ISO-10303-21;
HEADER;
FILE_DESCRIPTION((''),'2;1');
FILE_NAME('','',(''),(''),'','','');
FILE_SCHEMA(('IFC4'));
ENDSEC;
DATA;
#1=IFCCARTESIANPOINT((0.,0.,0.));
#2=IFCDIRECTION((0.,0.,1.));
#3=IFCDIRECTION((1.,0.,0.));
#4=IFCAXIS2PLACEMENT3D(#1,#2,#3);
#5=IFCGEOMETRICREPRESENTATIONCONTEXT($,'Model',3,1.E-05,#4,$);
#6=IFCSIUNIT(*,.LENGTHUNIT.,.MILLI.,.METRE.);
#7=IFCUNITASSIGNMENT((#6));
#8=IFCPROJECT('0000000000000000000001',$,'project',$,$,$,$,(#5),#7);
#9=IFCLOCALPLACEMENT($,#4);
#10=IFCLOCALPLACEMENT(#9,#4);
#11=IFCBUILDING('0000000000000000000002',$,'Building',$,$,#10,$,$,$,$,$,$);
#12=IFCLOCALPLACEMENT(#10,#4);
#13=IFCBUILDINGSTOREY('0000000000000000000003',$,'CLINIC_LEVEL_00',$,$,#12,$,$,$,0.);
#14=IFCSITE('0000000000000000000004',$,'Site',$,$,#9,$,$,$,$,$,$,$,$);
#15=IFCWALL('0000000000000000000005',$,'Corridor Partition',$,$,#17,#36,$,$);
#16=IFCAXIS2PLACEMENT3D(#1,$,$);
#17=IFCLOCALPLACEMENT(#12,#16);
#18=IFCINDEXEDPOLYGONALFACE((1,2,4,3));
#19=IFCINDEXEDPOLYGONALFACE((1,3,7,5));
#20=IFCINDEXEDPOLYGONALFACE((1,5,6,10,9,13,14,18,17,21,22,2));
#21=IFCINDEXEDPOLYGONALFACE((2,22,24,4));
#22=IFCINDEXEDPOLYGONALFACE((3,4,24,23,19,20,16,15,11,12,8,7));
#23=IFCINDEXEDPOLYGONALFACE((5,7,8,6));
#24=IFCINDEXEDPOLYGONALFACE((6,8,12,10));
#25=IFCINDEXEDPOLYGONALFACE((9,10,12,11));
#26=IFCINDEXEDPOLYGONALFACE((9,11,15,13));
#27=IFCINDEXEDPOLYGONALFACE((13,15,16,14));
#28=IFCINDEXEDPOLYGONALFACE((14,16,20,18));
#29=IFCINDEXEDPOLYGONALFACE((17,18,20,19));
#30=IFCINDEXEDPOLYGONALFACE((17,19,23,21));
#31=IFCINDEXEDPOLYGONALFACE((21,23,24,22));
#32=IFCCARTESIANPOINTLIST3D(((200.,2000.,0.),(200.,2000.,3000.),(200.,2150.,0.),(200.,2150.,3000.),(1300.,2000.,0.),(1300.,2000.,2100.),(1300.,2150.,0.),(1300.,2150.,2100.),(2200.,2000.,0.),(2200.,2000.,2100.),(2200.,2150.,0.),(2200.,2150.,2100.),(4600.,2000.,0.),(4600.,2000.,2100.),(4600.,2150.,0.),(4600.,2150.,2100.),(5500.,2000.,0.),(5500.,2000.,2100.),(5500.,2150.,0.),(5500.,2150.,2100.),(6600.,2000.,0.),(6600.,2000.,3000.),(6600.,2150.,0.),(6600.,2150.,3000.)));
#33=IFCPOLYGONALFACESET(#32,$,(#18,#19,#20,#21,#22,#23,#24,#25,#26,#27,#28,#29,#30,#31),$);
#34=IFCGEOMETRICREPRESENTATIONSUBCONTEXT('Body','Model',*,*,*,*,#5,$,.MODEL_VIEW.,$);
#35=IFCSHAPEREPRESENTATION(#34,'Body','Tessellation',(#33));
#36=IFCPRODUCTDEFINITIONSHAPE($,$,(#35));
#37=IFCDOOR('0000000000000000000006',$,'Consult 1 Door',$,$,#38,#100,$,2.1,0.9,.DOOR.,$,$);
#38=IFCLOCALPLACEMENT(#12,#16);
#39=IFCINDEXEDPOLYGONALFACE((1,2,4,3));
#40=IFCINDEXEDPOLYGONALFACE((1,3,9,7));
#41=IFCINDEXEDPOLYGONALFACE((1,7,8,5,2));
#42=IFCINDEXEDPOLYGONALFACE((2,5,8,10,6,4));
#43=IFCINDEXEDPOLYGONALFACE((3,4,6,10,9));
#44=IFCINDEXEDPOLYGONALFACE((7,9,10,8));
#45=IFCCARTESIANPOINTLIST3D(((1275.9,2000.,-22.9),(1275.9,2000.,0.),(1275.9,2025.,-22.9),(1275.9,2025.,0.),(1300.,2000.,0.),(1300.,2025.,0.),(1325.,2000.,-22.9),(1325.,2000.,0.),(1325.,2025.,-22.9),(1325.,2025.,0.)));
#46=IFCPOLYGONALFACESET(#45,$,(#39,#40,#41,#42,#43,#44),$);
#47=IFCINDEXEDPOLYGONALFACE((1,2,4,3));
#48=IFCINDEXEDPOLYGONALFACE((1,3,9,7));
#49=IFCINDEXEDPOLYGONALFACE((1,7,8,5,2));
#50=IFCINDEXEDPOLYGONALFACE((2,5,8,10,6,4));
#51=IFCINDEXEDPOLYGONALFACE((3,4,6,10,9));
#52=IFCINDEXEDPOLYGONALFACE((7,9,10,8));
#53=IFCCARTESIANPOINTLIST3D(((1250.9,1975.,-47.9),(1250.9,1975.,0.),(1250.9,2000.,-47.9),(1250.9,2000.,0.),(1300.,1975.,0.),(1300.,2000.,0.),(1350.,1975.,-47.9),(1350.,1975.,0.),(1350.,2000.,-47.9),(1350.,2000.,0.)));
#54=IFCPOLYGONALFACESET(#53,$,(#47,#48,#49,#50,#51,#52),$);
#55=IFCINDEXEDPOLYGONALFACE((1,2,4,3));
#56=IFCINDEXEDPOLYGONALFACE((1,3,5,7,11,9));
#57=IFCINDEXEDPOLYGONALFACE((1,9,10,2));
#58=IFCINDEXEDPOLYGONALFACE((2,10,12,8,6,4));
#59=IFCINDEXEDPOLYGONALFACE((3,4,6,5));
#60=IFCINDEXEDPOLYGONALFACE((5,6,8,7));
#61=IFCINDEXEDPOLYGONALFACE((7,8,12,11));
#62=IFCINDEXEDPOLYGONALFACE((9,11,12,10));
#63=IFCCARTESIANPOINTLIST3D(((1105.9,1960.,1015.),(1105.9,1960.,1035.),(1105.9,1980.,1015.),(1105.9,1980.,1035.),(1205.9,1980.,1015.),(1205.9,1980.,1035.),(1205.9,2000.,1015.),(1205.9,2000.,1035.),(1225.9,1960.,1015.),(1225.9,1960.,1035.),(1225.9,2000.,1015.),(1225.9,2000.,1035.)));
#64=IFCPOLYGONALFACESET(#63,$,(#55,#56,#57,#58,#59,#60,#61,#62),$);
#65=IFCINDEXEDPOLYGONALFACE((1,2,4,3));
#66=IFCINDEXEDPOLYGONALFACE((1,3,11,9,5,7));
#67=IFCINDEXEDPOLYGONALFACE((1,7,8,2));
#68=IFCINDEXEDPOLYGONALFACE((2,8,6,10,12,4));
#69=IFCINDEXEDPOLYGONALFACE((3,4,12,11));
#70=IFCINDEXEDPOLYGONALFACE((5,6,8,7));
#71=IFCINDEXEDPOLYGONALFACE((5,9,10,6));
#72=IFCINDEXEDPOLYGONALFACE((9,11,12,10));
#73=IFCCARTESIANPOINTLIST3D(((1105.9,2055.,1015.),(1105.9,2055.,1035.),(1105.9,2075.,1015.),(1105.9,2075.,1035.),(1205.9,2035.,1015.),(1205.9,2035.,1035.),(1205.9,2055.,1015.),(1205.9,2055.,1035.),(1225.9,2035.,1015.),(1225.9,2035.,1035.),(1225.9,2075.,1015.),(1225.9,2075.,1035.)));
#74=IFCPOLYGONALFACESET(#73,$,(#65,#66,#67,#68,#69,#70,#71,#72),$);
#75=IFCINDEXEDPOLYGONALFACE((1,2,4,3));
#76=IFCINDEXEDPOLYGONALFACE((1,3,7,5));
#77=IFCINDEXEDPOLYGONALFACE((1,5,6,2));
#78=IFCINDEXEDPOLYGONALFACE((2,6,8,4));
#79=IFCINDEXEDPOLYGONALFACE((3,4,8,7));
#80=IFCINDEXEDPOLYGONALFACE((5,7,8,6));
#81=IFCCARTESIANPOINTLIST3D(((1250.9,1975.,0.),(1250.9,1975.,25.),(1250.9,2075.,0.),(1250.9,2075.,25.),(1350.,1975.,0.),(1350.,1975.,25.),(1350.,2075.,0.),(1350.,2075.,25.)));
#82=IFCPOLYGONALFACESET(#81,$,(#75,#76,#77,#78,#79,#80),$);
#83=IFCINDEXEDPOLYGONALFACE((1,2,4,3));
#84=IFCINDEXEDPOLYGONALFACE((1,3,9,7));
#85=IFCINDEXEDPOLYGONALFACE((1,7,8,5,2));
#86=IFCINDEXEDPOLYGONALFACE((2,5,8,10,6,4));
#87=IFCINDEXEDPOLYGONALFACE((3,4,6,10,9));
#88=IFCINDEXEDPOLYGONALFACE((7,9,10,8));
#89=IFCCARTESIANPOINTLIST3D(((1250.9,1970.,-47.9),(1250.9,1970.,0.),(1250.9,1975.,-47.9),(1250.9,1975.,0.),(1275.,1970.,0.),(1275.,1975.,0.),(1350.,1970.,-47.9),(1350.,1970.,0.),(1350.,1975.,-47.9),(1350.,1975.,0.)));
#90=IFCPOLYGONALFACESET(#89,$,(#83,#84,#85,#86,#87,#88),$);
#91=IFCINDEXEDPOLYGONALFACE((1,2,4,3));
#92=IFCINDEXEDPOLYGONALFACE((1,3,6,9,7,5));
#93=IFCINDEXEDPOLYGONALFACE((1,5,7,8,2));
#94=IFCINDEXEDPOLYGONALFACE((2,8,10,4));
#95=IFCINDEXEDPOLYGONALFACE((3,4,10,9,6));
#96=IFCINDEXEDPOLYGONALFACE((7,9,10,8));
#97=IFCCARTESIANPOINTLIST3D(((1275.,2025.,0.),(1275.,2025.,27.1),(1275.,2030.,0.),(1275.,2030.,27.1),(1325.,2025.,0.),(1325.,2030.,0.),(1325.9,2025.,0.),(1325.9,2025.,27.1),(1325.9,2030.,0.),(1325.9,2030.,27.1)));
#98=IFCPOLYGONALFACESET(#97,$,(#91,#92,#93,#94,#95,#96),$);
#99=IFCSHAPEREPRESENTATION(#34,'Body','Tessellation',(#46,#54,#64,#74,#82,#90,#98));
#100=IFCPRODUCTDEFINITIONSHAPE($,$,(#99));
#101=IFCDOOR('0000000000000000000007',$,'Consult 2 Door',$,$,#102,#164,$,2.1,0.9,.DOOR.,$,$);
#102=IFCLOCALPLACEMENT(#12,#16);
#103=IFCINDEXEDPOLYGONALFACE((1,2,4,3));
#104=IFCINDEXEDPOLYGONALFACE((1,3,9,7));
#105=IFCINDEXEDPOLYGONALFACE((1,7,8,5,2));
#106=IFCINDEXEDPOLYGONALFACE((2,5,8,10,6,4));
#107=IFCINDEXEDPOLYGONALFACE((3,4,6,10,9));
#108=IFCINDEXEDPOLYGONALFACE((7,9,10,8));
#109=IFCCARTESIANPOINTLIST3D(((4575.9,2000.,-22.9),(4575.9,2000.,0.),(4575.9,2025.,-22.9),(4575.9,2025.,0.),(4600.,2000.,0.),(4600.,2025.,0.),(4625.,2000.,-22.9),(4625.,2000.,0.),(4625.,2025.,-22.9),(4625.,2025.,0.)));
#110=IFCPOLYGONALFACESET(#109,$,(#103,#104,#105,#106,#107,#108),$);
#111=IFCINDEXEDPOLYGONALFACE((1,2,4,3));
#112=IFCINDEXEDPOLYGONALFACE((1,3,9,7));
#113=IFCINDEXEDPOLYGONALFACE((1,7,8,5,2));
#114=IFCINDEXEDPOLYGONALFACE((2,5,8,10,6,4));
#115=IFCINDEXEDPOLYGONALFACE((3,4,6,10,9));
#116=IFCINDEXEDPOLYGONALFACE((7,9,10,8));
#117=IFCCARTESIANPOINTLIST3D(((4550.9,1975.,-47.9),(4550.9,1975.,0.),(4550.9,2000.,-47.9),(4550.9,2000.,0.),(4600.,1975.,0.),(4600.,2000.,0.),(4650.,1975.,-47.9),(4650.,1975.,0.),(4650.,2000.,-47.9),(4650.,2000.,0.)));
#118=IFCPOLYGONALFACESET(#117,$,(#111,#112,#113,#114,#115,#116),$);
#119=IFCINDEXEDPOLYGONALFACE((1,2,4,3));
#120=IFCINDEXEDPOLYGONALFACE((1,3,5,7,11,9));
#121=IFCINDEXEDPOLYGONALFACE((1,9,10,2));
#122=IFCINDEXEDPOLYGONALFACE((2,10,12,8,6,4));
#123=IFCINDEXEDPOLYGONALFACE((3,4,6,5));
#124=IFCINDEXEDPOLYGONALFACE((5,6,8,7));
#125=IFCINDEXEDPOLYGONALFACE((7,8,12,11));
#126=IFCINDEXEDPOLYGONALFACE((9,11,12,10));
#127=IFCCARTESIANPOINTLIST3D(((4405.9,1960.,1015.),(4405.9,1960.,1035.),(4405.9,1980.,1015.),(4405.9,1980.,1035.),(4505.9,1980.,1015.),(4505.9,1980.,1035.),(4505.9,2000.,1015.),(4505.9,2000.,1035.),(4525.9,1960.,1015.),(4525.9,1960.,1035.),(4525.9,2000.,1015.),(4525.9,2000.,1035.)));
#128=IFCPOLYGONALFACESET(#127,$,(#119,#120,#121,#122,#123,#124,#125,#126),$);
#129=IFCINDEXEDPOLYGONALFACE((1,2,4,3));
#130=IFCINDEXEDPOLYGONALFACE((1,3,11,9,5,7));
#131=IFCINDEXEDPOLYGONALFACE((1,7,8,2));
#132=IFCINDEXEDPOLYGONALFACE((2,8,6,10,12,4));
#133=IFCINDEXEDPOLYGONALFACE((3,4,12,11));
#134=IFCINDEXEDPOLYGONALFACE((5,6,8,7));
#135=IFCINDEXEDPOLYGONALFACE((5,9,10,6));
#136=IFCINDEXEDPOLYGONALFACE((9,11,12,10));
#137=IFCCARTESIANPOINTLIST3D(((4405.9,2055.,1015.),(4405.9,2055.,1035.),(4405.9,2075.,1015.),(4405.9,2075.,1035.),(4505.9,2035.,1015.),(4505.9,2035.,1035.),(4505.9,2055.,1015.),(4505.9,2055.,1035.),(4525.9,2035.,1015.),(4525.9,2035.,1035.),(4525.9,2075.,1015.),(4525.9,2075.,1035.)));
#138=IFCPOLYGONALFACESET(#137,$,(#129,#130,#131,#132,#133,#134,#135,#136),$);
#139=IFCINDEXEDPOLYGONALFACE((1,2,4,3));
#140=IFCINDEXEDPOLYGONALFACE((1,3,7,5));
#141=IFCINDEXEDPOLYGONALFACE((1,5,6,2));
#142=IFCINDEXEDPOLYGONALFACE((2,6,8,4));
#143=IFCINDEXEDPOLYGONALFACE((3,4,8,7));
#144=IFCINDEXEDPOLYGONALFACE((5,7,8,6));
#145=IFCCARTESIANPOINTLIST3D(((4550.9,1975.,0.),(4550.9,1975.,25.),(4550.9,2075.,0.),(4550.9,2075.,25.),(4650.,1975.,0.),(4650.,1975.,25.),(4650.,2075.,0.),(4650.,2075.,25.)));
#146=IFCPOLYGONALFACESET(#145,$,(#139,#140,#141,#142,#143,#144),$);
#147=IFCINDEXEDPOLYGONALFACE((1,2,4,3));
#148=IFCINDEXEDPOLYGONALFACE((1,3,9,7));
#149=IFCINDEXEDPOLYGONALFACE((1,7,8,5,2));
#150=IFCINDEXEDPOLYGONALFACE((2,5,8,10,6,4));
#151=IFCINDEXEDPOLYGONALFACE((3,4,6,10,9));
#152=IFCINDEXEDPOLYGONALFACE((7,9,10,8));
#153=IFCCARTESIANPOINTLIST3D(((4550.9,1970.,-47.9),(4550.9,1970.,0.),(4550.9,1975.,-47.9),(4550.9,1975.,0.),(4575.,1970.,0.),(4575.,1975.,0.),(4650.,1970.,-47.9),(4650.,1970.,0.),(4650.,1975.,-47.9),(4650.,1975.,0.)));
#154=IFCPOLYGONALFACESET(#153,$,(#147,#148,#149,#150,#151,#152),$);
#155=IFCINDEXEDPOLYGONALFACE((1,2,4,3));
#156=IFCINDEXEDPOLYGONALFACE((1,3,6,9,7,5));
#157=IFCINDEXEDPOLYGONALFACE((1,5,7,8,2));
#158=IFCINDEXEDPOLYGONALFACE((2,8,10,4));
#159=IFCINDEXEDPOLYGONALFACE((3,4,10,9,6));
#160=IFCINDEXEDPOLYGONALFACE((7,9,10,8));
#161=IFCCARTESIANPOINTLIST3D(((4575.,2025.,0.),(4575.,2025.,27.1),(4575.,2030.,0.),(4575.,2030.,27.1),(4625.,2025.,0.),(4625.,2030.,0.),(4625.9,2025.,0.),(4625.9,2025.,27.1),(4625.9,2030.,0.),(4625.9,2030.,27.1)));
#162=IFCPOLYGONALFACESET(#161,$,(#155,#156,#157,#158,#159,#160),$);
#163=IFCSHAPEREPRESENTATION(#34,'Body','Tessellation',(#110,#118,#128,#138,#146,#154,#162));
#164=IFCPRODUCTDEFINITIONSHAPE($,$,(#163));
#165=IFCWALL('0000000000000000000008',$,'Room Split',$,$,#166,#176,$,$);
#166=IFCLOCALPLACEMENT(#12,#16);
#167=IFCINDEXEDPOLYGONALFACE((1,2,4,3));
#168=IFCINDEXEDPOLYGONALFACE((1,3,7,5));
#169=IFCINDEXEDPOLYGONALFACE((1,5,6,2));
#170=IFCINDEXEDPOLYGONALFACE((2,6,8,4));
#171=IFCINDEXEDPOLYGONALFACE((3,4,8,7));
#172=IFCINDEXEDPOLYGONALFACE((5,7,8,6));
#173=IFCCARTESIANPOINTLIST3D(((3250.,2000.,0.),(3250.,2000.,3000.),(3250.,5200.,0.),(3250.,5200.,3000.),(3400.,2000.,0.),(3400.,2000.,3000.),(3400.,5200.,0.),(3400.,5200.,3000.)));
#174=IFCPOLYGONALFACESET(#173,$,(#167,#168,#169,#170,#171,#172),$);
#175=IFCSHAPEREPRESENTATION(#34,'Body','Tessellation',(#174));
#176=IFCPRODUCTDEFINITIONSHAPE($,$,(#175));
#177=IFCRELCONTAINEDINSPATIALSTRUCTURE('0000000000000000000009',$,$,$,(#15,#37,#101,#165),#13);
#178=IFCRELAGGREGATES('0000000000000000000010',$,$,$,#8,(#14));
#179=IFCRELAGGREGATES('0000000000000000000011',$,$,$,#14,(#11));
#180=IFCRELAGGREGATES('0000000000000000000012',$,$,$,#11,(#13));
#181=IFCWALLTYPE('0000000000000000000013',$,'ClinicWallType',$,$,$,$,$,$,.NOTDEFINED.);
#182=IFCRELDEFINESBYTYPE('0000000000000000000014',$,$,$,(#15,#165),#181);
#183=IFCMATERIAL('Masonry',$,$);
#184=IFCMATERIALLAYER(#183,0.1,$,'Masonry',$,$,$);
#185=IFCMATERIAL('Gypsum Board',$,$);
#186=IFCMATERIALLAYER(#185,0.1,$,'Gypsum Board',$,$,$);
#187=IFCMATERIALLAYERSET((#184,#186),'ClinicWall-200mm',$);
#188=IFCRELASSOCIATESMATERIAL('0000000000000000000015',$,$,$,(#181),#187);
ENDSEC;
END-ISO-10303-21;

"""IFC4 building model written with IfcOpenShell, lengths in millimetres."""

from ifc_helpers import new_model, si_unit, frame, origin_with_axes, place, context, subcontext, project, spatial, line, indexed_curve, outline, extrude, material, layer, layer_set, type_object, element, fill, save


model = new_model("IFC4")

# Units and contexts
model_context = context("Model", 3, precision=1e-05, world=origin_with_axes())
body_context = subcontext(model_context, "Body", "Model", "MODEL_VIEW")
ifc_project = project(units=[si_unit("LENGTHUNIT", "METRE", prefix="MILLI")], contexts=[model_context])

# Site, building, storey
site_placement = place(None, origin_with_axes())
site = spatial("IfcSite", under=ifc_project, at=site_placement, Name="Site")
building_placement = place(site_placement, origin_with_axes())
building = spatial("IfcBuilding", under=site, at=building_placement, Name="Building")
storey_placement = place(building_placement, origin_with_axes())
storey = spatial("IfcBuildingStorey", under=building, at=storey_placement, Name="CLINIC_LEVEL_00", Elevation=0.0)

# Shared definitions
ifc_material_1 = material(Name="Masonry")
ifc_layer_1 = layer(ifc_material_1, 0.1, Name="Masonry")
ifc_material_2 = material(Name="Gypsum Board")
ifc_layer_2 = layer(ifc_material_2, 0.1, Name="Gypsum Board")
ifc_layer_set_1 = layer_set([ifc_layer_1, ifc_layer_2], Name="ClinicWall-200mm")
wall_type = type_object("IfcWallType", Name="ClinicWallType", PredefinedType="NOTDEFINED", material=ifc_layer_set_1)

# Wall, openings, doors
wall_1_placement = place(storey_placement, frame((200.0, 2000.0, 0.0), z_axis=(0.0, 0.0, 1.0), x_axis=(1.0, 0.0, 0.0)))
wall_1 = element("IfcWall", 1, at=wall_1_placement, inside=storey, type_object=wall_type, Name="Corridor Partition", context=body_context, shape_type="SweptSolid", body=[
    extrude(outline(indexed_curve([(0.0, 0.0), (0.0, 150.0), (6400.0, 150.0), (6400.0, 0.0), (0.0, 0.0)], self_intersect=False)), origin_with_axes(), (0.0, 0.0, 1.0), 3000.0),
])
opening_1_placement = place(wall_1_placement, frame((1100.0, -25.0, 0.0), z_axis=(0.0, 0.0, 1.0), x_axis=(1.0, 0.0, 0.0)))
opening_1 = element("IfcOpeningElement", 2, at=opening_1_placement, cuts=wall_1, context=body_context, shape_type="SweptSolid", body=[
    extrude(outline(indexed_curve([(0.0, 0.0), (0.0, 200.0), (900.0, 200.0), (900.0, 0.0), (0.0, 0.0)], self_intersect=False)), origin_with_axes(), (0.0, 0.0, 1.0), 2100.0),
])
opening_2_placement = place(wall_1_placement, frame((4400.0, -25.0, 0.0), z_axis=(0.0, 0.0, 1.0), x_axis=(1.0, 0.0, 0.0)))
opening_2 = element("IfcOpeningElement", 3, at=opening_2_placement, cuts=wall_1, context=body_context, shape_type="SweptSolid", body=[
    extrude(outline(indexed_curve([(0.0, 0.0), (0.0, 200.0), (900.0, 200.0), (900.0, 0.0), (0.0, 0.0)], self_intersect=False)), origin_with_axes(), (0.0, 0.0, 1.0), 2100.0),
])
door_1_placement = place(storey_placement, frame((1300.0, 1975.0, 0.0), z_axis=(0.0, 0.0, 1.0), x_axis=(1.0, 0.0, 0.0)))
door_1 = element("IfcDoor", 4, at=door_1_placement, inside=storey, Name="Consult 1 Door", OverallHeight=2.1, OverallWidth=0.9, PredefinedType="DOOR", context=body_context, shape_type="SweptSolid", body=[
    extrude(outline(indexed_curve([(0.0, 0.0), (0.0, 2.1), (0.9, 2.1), (0.9, 0.0), (-24.1, 0.0), (-24.1, -22.9), (25.0, -22.9), (25.0, 0.0)], segments=[line(1, 2, 3, 4, 5, 6, 7, 8, 1)])), frame((0.0, 25.0, 0.0), z_axis=(0.0, -1.0, 0.0), x_axis=(1.0, 0.0, 0.0)), (0.0, 0.0, -1.0), 25.0),
    extrude(outline(indexed_curve([(0.0, 0.0), (0.0, 2.1), (0.9, 2.1), (0.9, 0.0), (-49.1, 0.0), (-49.1, -47.9), (50.0, -47.9), (50.0, 0.0)], segments=[line(1, 2, 3, 4, 5, 6, 7, 8, 1)])), frame((0.0, 0.0, 0.0), z_axis=(0.0, -1.0, 0.0), x_axis=(1.0, 0.0, 0.0)), (0.0, 0.0, -1.0), 25.0),
    extrude(outline(indexed_curve([(0.0, 0.0), (-49.1, 0.0), (-49.1, 35.0), (0.0, 35.0)], segments=[line(1, 2, 3, 4, 1)])), frame((25.0, 25.0, 25.0), z_axis=(0.0, 0.0, 1.0), x_axis=(1.0, 0.0, 0.0)), (0.0, 0.0, 1.0), -47.9),
    extrude(outline(indexed_curve([(0.0, 0.0), (0.0, -40.0), (-120.0, -40.0), (-120.0, -20.0), (-20.0, -20.0), (-20.0, 0.0)], segments=[line(1, 2, 3, 4, 5, 6, 1)])), frame((-74.1, 25.0, 1015.0), z_axis=(0.0, 0.0, 1.0), x_axis=(1.0, 0.0, 0.0)), (0.0, 0.0, 1.0), 20.0),
    extrude(outline(indexed_curve([(0.0, 0.0), (0.0, 40.0), (-120.0, 40.0), (-120.0, 20.0), (-20.0, 20.0), (-20.0, 0.0)], segments=[line(1, 2, 3, 4, 5, 6, 1)])), frame((-74.1, 60.0, 1015.0), z_axis=(0.0, 0.0, 1.0), x_axis=(1.0, 0.0, 0.0)), (0.0, 0.0, 1.0), 20.0),
    extrude(outline(indexed_curve([(0.0, 0.0), (-99.1, 0.0), (-99.1, 100.0), (0.0, 100.0)], segments=[line(1, 2, 3, 4, 1)])), frame((50.0, 0.0, 0.0), z_axis=(0.0, 0.0, 1.0), x_axis=(1.0, 0.0, 0.0)), (0.0, 0.0, 1.0), 25.0),
    extrude(outline(indexed_curve([(0.0, 0.0), (0.0, 27.1), (50.9, 27.1), (50.9, 0.0), (-24.1, 0.0), (-24.1, -47.9), (75.0, -47.9), (75.0, 0.0)], segments=[line(1, 2, 3, 4, 5, 6, 7, 8, 1)])), frame((-25.0, -5.0, 0.0), z_axis=(0.0, -1.0, 0.0), x_axis=(1.0, 0.0, 0.0)), (0.0, 0.0, -1.0), 5.0),
    extrude(outline(indexed_curve([(0.0, 0.0), (0.0, 27.1), (50.9, 27.1), (50.9, 0.0), (0.9, 0.0), (0.9, -22.9), (50.0, -22.9), (50.0, 0.0)], segments=[line(1, 2, 3, 4, 5, 6, 7, 8, 1)])), frame((-25.0, 50.0, 0.0), z_axis=(0.0, -1.0, 0.0), x_axis=(1.0, 0.0, 0.0)), (0.0, 0.0, -1.0), 5.0),
])
fill(opening_1, door_1)
door_2_placement = place(storey_placement, frame((4600.0, 1975.0, 0.0), z_axis=(0.0, 0.0, 1.0), x_axis=(1.0, 0.0, 0.0)))
door_2 = element("IfcDoor", 5, at=door_2_placement, inside=storey, Name="Consult 2 Door", OverallHeight=2.1, OverallWidth=0.9, PredefinedType="DOOR", context=body_context, shape_type="SweptSolid", body=[
    extrude(outline(indexed_curve([(0.0, 0.0), (0.0, 2.1), (0.9, 2.1), (0.9, 0.0), (-24.1, 0.0), (-24.1, -22.9), (25.0, -22.9), (25.0, 0.0)], segments=[line(1, 2, 3, 4, 5, 6, 7, 8, 1)])), frame((0.0, 25.0, 0.0), z_axis=(0.0, -1.0, 0.0), x_axis=(1.0, 0.0, 0.0)), (0.0, 0.0, -1.0), 25.0),
    extrude(outline(indexed_curve([(0.0, 0.0), (0.0, 2.1), (0.9, 2.1), (0.9, 0.0), (-49.1, 0.0), (-49.1, -47.9), (50.0, -47.9), (50.0, 0.0)], segments=[line(1, 2, 3, 4, 5, 6, 7, 8, 1)])), frame((0.0, 0.0, 0.0), z_axis=(0.0, -1.0, 0.0), x_axis=(1.0, 0.0, 0.0)), (0.0, 0.0, -1.0), 25.0),
    extrude(outline(indexed_curve([(0.0, 0.0), (-49.1, 0.0), (-49.1, 35.0), (0.0, 35.0)], segments=[line(1, 2, 3, 4, 1)])), frame((25.0, 25.0, 25.0), z_axis=(0.0, 0.0, 1.0), x_axis=(1.0, 0.0, 0.0)), (0.0, 0.0, 1.0), -47.9),
    extrude(outline(indexed_curve([(0.0, 0.0), (0.0, -40.0), (-120.0, -40.0), (-120.0, -20.0), (-20.0, -20.0), (-20.0, 0.0)], segments=[line(1, 2, 3, 4, 5, 6, 1)])), frame((-74.1, 25.0, 1015.0), z_axis=(0.0, 0.0, 1.0), x_axis=(1.0, 0.0, 0.0)), (0.0, 0.0, 1.0), 20.0),
    extrude(outline(indexed_curve([(0.0, 0.0), (0.0, 40.0), (-120.0, 40.0), (-120.0, 20.0), (-20.0, 20.0), (-20.0, 0.0)], segments=[line(1, 2, 3, 4, 5, 6, 1)])), frame((-74.1, 60.0, 1015.0), z_axis=(0.0, 0.0, 1.0), x_axis=(1.0, 0.0, 0.0)), (0.0, 0.0, 1.0), 20.0),
    extrude(outline(indexed_curve([(0.0, 0.0), (-99.1, 0.0), (-99.1, 100.0), (0.0, 100.0)], segments=[line(1, 2, 3, 4, 1)])), frame((50.0, 0.0, 0.0), z_axis=(0.0, 0.0, 1.0), x_axis=(1.0, 0.0, 0.0)), (0.0, 0.0, 1.0), 25.0),
    extrude(outline(indexed_curve([(0.0, 0.0), (0.0, 27.1), (50.9, 27.1), (50.9, 0.0), (-24.1, 0.0), (-24.1, -47.9), (75.0, -47.9), (75.0, 0.0)], segments=[line(1, 2, 3, 4, 5, 6, 7, 8, 1)])), frame((-25.0, -5.0, 0.0), z_axis=(0.0, -1.0, 0.0), x_axis=(1.0, 0.0, 0.0)), (0.0, 0.0, -1.0), 5.0),
    extrude(outline(indexed_curve([(0.0, 0.0), (0.0, 27.1), (50.9, 27.1), (50.9, 0.0), (0.9, 0.0), (0.9, -22.9), (50.0, -22.9), (50.0, 0.0)], segments=[line(1, 2, 3, 4, 5, 6, 7, 8, 1)])), frame((-25.0, 50.0, 0.0), z_axis=(0.0, -1.0, 0.0), x_axis=(1.0, 0.0, 0.0)), (0.0, 0.0, -1.0), 5.0),
])
fill(opening_2, door_2)

# Wall
wall_2_placement = place(storey_placement, frame((3400.0, 2000.0, 0.0), z_axis=(0.0, 0.0, 1.0), x_axis=(0.0, 1.0, 0.0)))
element("IfcWall", 6, at=wall_2_placement, inside=storey, type_object=wall_type, Name="Room Split", context=body_context, shape_type="SweptSolid", body=[
    extrude(outline(indexed_curve([(0.0, 0.0), (0.0, 150.0), (3200.0, 150.0), (3200.0, 0.0), (0.0, 0.0)], self_intersect=False)), origin_with_axes(), (0.0, 0.0, 1.0), 3000.0),
])

save(model, "model.ifc")
